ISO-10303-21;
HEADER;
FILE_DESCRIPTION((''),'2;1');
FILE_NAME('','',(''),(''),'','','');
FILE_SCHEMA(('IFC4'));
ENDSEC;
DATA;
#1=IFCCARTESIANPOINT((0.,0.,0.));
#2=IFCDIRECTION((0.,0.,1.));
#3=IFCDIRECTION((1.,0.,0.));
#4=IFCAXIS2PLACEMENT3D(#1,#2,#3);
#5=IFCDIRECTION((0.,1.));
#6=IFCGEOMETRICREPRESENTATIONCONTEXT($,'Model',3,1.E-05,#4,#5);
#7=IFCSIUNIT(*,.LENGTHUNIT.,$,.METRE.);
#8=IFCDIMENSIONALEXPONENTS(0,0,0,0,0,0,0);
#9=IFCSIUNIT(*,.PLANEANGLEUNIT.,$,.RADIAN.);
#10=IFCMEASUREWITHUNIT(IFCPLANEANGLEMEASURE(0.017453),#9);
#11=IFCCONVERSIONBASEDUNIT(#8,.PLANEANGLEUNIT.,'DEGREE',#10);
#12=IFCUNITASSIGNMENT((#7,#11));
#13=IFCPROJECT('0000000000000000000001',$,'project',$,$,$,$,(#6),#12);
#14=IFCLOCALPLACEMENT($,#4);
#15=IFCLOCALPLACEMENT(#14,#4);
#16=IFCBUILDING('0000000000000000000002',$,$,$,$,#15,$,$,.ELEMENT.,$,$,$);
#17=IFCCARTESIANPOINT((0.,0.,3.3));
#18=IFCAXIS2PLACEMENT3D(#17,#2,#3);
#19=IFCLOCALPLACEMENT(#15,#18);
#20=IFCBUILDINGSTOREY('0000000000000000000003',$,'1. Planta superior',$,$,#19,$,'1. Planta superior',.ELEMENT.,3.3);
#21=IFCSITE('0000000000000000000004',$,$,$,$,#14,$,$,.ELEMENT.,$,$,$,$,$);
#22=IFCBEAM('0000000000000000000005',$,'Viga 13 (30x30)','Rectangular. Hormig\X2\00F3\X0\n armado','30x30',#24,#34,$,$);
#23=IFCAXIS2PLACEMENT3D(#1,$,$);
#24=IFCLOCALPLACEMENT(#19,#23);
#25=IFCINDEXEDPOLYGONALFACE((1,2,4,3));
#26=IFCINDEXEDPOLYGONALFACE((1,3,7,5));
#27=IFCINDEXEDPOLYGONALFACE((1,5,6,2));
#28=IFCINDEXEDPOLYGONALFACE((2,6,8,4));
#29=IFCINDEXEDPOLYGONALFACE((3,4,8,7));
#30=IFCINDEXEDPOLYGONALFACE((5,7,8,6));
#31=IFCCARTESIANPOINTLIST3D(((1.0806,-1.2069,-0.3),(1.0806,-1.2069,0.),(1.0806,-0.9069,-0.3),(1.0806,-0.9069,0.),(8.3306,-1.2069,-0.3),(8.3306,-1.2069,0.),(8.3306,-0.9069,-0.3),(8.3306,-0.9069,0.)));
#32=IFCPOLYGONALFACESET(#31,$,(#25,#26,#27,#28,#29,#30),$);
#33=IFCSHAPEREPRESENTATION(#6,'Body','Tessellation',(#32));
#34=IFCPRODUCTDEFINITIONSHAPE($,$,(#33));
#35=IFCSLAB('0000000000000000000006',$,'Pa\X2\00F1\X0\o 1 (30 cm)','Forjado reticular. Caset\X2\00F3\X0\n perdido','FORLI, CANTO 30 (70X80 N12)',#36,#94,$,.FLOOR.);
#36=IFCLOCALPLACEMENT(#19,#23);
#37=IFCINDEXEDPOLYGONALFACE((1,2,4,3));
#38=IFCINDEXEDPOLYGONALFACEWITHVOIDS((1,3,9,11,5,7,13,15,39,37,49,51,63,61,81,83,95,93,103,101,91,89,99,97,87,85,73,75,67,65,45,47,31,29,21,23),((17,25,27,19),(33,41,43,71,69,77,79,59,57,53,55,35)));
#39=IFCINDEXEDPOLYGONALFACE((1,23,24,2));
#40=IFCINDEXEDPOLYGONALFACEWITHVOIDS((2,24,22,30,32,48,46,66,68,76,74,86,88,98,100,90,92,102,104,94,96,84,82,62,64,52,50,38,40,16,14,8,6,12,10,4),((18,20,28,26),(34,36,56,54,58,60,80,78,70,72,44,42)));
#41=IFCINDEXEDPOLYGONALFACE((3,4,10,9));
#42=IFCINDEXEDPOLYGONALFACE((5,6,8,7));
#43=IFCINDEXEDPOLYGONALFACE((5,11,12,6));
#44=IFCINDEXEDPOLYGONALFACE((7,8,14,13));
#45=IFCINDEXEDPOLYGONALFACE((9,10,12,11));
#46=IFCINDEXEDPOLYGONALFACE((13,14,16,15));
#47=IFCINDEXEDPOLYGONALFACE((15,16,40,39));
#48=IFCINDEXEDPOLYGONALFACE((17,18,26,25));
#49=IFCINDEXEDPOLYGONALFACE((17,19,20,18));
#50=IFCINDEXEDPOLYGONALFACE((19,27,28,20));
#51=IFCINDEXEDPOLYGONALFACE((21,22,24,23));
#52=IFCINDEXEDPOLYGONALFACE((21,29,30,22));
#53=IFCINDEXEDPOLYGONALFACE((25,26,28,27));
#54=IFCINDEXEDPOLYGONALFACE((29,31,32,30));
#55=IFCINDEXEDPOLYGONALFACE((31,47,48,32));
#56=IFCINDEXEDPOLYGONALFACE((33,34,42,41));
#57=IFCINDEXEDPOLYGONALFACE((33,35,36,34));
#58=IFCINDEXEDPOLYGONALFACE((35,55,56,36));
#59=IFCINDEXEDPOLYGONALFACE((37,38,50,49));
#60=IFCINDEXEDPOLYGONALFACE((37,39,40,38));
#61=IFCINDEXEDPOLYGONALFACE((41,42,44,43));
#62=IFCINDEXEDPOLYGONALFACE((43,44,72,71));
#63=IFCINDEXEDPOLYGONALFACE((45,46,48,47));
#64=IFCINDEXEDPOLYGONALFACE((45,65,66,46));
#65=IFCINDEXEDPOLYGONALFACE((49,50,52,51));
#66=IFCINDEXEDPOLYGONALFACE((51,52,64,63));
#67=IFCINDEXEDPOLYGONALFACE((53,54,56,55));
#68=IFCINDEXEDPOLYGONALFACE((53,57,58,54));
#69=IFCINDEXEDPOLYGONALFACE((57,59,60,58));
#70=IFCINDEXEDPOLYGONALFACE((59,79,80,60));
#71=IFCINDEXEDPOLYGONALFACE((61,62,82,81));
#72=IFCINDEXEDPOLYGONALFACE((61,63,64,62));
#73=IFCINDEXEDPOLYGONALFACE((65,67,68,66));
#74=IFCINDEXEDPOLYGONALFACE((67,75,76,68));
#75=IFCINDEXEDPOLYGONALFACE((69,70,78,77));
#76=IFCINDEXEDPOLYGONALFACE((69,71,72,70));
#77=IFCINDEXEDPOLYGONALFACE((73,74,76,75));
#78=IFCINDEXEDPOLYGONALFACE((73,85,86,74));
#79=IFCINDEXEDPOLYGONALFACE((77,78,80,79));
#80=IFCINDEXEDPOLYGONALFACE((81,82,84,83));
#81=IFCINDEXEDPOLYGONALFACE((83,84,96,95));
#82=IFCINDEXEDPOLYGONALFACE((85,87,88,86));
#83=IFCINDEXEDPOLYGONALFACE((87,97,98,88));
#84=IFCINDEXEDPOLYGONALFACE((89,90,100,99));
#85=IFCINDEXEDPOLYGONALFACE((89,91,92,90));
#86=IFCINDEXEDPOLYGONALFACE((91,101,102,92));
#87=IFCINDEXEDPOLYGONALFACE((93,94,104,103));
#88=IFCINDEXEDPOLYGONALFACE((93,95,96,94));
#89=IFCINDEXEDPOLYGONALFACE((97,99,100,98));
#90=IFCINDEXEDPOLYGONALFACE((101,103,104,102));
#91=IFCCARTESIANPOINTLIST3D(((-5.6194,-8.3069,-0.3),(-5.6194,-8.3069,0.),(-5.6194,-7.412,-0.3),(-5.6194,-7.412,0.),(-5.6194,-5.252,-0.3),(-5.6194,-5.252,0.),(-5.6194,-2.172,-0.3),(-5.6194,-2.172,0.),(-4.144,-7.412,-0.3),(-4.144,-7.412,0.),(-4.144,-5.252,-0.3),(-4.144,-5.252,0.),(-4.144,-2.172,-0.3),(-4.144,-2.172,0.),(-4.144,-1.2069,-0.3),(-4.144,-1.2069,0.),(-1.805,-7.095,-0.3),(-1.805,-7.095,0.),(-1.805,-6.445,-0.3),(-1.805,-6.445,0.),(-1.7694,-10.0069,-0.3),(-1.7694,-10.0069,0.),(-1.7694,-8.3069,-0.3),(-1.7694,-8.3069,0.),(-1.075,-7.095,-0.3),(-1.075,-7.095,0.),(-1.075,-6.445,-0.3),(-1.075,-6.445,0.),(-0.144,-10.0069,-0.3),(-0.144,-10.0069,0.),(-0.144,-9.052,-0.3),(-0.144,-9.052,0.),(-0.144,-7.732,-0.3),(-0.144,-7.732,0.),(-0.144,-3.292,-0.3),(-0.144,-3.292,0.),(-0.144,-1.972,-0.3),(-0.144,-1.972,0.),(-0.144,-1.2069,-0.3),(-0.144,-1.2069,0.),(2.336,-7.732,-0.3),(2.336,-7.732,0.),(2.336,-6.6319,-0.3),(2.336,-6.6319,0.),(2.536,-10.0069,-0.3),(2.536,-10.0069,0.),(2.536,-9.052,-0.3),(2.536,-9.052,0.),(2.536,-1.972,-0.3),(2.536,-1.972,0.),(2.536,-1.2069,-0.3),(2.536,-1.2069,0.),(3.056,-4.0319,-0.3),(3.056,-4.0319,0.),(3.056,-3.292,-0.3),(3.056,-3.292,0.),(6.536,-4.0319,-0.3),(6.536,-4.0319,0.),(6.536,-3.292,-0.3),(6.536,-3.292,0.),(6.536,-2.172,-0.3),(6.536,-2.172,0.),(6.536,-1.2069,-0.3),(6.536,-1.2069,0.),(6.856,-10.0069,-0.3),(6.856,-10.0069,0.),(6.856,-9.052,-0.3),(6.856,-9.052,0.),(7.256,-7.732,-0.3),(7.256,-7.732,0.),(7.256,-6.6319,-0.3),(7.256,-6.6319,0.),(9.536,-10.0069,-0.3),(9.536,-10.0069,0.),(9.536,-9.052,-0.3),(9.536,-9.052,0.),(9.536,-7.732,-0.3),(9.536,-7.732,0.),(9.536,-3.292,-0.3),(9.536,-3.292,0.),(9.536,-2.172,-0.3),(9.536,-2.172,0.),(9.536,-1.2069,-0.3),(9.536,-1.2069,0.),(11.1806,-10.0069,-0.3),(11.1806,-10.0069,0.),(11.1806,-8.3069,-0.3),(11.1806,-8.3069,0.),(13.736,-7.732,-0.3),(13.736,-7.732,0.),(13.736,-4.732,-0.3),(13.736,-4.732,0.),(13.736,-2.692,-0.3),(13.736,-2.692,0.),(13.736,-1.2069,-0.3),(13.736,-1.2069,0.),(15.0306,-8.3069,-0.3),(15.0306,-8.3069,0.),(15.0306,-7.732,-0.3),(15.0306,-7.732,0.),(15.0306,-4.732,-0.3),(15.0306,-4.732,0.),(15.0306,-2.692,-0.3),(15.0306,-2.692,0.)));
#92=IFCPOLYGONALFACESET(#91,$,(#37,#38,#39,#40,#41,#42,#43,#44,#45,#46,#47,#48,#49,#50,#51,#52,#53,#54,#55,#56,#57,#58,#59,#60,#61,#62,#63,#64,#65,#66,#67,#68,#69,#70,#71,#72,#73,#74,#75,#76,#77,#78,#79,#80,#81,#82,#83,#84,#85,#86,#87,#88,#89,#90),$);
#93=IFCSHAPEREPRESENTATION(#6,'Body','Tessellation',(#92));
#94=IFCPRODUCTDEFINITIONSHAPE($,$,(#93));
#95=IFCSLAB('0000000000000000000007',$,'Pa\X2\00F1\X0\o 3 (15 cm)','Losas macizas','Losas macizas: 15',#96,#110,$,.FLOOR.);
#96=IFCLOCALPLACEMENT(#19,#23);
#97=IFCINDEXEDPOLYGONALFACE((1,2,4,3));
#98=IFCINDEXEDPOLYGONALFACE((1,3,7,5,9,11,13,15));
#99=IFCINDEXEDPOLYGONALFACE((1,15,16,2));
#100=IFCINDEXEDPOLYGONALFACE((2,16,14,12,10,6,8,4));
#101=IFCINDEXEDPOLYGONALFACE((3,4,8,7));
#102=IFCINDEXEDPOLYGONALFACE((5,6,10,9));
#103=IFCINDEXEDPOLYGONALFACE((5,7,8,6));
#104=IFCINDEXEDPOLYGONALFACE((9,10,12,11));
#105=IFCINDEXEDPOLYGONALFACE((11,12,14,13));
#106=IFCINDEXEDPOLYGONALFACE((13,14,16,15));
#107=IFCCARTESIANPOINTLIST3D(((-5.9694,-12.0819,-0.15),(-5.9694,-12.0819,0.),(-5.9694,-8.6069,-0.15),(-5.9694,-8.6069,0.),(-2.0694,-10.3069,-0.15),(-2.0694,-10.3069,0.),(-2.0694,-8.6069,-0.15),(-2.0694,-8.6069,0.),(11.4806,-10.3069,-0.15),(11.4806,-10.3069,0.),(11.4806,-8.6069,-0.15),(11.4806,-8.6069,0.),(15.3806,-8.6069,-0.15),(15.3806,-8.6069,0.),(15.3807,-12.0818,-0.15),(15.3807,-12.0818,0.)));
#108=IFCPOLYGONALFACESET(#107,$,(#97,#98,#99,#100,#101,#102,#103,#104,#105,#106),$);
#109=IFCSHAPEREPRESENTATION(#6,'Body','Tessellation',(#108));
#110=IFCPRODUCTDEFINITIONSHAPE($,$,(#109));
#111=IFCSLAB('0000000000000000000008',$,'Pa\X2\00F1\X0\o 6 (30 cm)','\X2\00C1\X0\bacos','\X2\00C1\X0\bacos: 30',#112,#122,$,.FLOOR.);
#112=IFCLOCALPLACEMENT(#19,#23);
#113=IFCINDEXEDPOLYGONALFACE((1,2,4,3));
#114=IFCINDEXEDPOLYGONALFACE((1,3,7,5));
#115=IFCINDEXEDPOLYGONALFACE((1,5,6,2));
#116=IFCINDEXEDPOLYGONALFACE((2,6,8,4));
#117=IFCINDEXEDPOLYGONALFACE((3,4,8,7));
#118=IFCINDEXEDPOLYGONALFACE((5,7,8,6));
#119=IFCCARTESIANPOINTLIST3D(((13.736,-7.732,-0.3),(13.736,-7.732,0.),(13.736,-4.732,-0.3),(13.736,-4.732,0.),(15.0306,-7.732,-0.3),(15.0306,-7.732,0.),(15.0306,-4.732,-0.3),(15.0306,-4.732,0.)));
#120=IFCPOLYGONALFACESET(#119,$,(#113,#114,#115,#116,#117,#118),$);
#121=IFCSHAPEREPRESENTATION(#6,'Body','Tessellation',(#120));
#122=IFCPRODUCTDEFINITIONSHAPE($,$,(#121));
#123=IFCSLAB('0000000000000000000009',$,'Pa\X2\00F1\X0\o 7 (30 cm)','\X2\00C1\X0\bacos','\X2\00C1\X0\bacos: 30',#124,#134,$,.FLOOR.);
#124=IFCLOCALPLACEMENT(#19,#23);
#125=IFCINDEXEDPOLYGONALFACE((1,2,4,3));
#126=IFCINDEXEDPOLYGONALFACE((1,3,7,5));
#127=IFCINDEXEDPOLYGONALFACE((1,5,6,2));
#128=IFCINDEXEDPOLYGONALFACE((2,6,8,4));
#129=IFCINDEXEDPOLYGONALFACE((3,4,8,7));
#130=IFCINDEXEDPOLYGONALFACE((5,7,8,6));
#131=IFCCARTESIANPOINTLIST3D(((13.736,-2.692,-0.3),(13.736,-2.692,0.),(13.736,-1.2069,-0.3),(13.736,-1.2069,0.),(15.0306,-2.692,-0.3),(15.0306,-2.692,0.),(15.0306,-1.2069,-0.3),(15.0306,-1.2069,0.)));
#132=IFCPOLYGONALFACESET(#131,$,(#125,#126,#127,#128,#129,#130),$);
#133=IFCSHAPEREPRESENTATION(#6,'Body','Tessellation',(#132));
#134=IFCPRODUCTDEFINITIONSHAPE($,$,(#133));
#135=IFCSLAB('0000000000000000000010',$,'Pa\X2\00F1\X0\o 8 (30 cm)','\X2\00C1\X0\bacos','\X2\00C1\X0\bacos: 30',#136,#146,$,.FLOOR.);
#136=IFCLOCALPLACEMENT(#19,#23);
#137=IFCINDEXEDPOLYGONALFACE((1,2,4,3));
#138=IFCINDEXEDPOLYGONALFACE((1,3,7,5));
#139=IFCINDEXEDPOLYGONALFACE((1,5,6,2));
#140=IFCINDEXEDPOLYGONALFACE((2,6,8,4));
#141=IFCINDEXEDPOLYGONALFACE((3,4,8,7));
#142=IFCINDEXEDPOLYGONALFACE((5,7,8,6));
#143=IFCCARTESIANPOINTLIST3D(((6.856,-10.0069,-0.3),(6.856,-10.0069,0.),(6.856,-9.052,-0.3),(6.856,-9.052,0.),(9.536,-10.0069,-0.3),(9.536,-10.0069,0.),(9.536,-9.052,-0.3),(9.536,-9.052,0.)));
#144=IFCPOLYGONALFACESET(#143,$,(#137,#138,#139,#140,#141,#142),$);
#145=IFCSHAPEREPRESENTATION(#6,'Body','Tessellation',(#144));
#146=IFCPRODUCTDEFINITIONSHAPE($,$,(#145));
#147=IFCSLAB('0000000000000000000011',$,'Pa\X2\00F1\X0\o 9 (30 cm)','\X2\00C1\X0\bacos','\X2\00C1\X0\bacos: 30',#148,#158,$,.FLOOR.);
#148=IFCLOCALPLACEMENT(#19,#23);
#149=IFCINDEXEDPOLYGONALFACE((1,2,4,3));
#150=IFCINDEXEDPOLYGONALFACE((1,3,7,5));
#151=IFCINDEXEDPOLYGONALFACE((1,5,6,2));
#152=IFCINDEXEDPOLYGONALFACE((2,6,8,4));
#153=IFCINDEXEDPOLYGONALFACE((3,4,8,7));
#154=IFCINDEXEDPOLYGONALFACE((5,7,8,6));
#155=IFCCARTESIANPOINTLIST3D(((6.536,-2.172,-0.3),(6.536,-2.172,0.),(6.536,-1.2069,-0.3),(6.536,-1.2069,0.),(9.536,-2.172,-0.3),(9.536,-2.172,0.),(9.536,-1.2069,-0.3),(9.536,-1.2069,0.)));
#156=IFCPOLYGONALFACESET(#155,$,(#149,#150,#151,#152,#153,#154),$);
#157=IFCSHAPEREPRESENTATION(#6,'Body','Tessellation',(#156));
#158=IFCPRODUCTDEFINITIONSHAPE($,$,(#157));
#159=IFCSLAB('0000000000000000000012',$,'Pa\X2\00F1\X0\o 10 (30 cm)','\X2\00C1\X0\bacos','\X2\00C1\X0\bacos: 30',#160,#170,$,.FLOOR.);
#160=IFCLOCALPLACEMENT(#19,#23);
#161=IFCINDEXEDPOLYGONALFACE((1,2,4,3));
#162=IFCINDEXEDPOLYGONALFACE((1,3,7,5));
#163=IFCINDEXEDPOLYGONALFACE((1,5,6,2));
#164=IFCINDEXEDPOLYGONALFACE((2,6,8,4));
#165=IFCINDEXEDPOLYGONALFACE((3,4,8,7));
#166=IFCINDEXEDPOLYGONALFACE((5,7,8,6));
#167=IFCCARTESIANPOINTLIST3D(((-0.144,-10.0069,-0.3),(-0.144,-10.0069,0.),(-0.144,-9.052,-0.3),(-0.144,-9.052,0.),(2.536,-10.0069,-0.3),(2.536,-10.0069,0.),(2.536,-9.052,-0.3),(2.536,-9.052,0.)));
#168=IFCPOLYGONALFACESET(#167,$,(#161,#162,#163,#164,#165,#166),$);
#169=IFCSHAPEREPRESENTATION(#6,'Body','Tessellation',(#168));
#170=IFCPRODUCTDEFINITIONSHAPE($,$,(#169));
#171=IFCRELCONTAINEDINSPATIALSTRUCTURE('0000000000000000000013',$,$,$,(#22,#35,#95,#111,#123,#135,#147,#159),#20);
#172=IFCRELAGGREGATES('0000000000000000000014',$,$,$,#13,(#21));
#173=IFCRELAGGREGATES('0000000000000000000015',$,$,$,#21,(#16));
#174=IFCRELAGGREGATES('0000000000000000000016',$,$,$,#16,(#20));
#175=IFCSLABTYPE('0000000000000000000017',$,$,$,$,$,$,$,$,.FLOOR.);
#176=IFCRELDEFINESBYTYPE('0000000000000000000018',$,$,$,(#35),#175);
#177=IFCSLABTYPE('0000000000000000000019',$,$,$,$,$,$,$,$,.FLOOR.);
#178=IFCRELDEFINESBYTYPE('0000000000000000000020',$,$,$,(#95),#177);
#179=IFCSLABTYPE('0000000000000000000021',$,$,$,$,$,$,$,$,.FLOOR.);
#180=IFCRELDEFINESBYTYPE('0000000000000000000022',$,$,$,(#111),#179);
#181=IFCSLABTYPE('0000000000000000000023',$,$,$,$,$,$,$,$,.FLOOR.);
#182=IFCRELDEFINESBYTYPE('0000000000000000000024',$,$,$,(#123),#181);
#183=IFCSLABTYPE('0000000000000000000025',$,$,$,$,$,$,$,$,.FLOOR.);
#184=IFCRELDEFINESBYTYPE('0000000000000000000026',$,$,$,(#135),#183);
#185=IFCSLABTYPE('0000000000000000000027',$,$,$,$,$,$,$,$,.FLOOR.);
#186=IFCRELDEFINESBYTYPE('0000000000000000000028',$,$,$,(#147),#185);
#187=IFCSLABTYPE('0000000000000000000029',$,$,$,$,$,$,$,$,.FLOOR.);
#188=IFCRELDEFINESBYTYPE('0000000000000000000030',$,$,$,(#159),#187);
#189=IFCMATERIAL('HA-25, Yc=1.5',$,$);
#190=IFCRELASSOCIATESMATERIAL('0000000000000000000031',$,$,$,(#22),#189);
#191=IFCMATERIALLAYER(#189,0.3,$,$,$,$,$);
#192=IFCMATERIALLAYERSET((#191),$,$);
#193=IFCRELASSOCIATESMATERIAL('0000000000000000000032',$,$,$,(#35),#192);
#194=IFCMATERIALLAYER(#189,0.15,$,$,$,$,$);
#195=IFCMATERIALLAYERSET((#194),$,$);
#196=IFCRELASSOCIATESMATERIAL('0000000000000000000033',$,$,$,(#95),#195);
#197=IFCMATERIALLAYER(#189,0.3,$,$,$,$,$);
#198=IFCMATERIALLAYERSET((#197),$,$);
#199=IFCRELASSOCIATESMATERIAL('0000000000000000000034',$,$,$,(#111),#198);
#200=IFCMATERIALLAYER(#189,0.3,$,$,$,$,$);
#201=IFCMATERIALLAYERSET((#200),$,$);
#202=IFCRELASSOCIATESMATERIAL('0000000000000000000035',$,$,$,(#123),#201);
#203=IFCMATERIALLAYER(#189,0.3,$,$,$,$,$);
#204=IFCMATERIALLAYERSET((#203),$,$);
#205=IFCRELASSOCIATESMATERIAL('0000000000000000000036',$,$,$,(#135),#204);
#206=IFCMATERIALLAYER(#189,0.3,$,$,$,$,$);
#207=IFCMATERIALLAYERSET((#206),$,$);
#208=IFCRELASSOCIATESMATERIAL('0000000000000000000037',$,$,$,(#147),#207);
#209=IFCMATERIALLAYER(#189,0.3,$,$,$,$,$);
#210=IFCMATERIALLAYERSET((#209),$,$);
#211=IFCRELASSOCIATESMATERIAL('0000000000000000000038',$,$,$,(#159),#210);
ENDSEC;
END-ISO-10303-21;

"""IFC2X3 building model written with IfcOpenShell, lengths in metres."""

from ifc_helpers import new_model, entity, si_unit, converted_unit, direction, frame, frame_2d, origin_with_axes, place, context, project, spatial, polyline, rectangle, outline, extrude, material, layer, layer_set, layer_usage, type_object, element, save


model = new_model("IFC2X3")

# Units and contexts
model_context = context("Model", 3, precision=1e-05, world=origin_with_axes(), true_north=direction((0.0, 1.0)))
ifc_project = project(units=[si_unit("LENGTHUNIT", "METRE"), converted_unit("PLANEANGLEUNIT", "DEGREE", entity("IfcPlaneAngleMeasure", 0.017453), si_unit("PLANEANGLEUNIT", "RADIAN"), dimensions=[0, 0, 0, 0, 0, 0, 0])], contexts=[model_context])

# Site, building, storey
site_placement = place(None, origin_with_axes())
site = spatial("IfcSite", under=ifc_project, at=site_placement, CompositionType="ELEMENT")
building_placement = place(site_placement, origin_with_axes())
building = spatial("IfcBuilding", under=site, at=building_placement, CompositionType="ELEMENT")
storey_placement = place(building_placement, frame((0.0, 0.0, 3.3), z_axis=(0.0, 0.0, 1.0), x_axis=(1.0, 0.0, 0.0)))
storey = spatial("IfcBuildingStorey", under=building, at=storey_placement, Name="1. Planta superior", LongName="1. Planta superior", CompositionType="ELEMENT", Elevation=3.3)

# Beam
ifc_material_1 = material(Name="HA-25, Yc=1.5")
beam_placement = place(storey_placement, frame((1.0806, -1.0569, 0.0), z_axis=(1.0, 0.0, 0.0), x_axis=(0.0, 1.0, 0.0)))
element("IfcBeam", 1, at=beam_placement, inside=storey, material=ifc_material_1, Name="Viga 13 (30x30)", Description="Rectangular. Hormigón armado", ObjectType="30x30", context=model_context, shape_type="SweptSolid", body=[
    extrude(rectangle(XDim=0.3, YDim=0.3, at=frame_2d((0.0, -0.15), x_axis=(1.0, 0.0))), origin_with_axes(), (0.0, 0.0, 1.0), 7.25),
])

# Slab, openings
ifc_layer_1 = layer(ifc_material_1, 0.3)
ifc_layer_set_1 = layer_set([ifc_layer_1])
ifc_layer_usage_1 = layer_usage(ifc_layer_set_1, "AXIS3", "POSITIVE", 0.0)
slab_type_1 = type_object("IfcSlabType", PredefinedType="FLOOR")
slab_1_placement = place(storey_placement, frame((0.0, 0.0, -0.3), z_axis=(0.0, 0.0, 1.0), x_axis=(1.0, 0.0, 0.0)))
slab_1 = element("IfcSlab", 2, at=slab_1_placement, inside=storey, type_object=slab_type_1, material=ifc_layer_usage_1, Name="Paño 1 (30 cm)", Description="Forjado reticular. Casetón perdido", ObjectType="FORLI, CANTO 30 (70X80 N12)", PredefinedType="FLOOR", context=model_context, shape_type="SweptSolid", body=[
    extrude(outline(polyline([(15.0306, -8.3069), (15.0306, -7.732), (13.736, -7.732), (13.736, -4.732), (15.0306, -4.732), (15.0306, -2.692), (13.736, -2.692), (13.736, -1.2069), (9.536, -1.2069), (9.536, -2.172), (6.536, -2.172), (6.536, -1.2069), (2.536, -1.2069), (2.536, -1.972), (-0.144, -1.972), (-0.144, -1.2069), (-4.144, -1.2069), (-4.144, -2.172), (-5.6194, -2.172), (-5.6194, -5.252), (-4.144, -5.252), (-4.144, -7.412), (-5.6194, -7.412), (-5.6194, -8.3069), (-1.7694, -8.3069), (-1.7694, -10.0069), (-0.144, -10.0069), (-0.144, -9.052), (2.536, -9.052), (2.536, -10.0069), (6.856, -10.0069), (6.856, -9.052), (9.536, -9.052), (9.536, -10.0069), (11.1806, -10.0069), (11.1806, -8.3069), (15.0306, -8.3069)])), origin_with_axes(), (0.0, 0.0, 1.0), 0.3),
])
opening_1_placement = place(slab_1_placement, frame((-0.144, -7.732, 0.0), z_axis=(0.0, 0.0, 1.0), x_axis=(1.0, 0.0, 0.0)))
element("IfcOpeningElement", 3, at=opening_1_placement, cuts=slab_1, ObjectType="Opening", context=model_context, shape_type="SweptSolid", body=[
    extrude(outline(polyline([(7.4, 0.0), (9.68, 0.0), (9.68, 4.44), (6.68, 4.44), (6.68, 3.7001), (3.2, 3.7001), (3.2, 4.44), (0.0, 4.44), (0.0, 0.0), (2.48, 0.0), (2.48, 1.1001), (7.4, 1.1001), (7.4, 0.0)])), origin_with_axes(), (0.0, 0.0, 1.0), 0.3),
])
opening_2_placement = place(slab_1_placement, frame((-1.805, -7.095, 0.0), z_axis=(0.0, 0.0, 1.0), x_axis=(1.0, 0.0, 0.0)))
element("IfcOpeningElement", 4, at=opening_2_placement, cuts=slab_1, ObjectType="Opening", context=model_context, shape_type="SweptSolid", body=[
    extrude(outline(polyline([(0.0, 0.0), (0.73, 0.0), (0.73, 0.65), (0.0, 0.65), (0.0, 0.0)])), origin_with_axes(), (0.0, 0.0, 1.0), 0.3),
])

# Slabs
ifc_layer_2 = layer(ifc_material_1, 0.15)
ifc_layer_set_2 = layer_set([ifc_layer_2])
ifc_layer_usage_2 = layer_usage(ifc_layer_set_2, "AXIS3", "POSITIVE", 0.0)
slab_type_2 = type_object("IfcSlabType", PredefinedType="FLOOR")
slab_2_placement = place(storey_placement, frame((0.0, 0.0, -0.15), z_axis=(0.0, 0.0, 1.0), x_axis=(1.0, 0.0, 0.0)))
element("IfcSlab", 5, at=slab_2_placement, inside=storey, type_object=slab_type_2, material=ifc_layer_usage_2, Name="Paño 3 (15 cm)", Description="Losas macizas", ObjectType="Losas macizas: 15", PredefinedType="FLOOR", context=model_context, shape_type="SweptSolid", body=[
    extrude(outline(polyline([(15.3806, -8.6069), (11.4806, -8.6069), (11.4806, -10.3069), (-2.0694, -10.3069), (-2.0694, -8.6069), (-5.9694, -8.6069), (-5.9694, -12.0819), (15.3807, -12.0818), (15.3806, -8.6069)])), origin_with_axes(), (0.0, 0.0, 1.0), 0.15),
])
ifc_layer_3 = layer(ifc_material_1, 0.3)
ifc_layer_set_3 = layer_set([ifc_layer_3])
ifc_layer_usage_3 = layer_usage(ifc_layer_set_3, "AXIS3", "POSITIVE", 0.0)
slab_type_3 = type_object("IfcSlabType", PredefinedType="FLOOR")
slab_3_placement = place(storey_placement, frame((0.0, 0.0, -0.3), z_axis=(0.0, 0.0, 1.0), x_axis=(1.0, 0.0, 0.0)))
element("IfcSlab", 6, at=slab_3_placement, inside=storey, type_object=slab_type_3, material=ifc_layer_usage_3, Name="Paño 6 (30 cm)", Description="Ábacos", ObjectType="Ábacos: 30", PredefinedType="FLOOR", context=model_context, shape_type="SweptSolid", body=[
    extrude(outline(polyline([(15.0306, -4.732), (13.736, -4.732), (13.736, -7.732), (15.0306, -7.732), (15.0306, -4.732)])), origin_with_axes(), (0.0, 0.0, 1.0), 0.3),
])
ifc_layer_4 = layer(ifc_material_1, 0.3)
ifc_layer_set_4 = layer_set([ifc_layer_4])
ifc_layer_usage_4 = layer_usage(ifc_layer_set_4, "AXIS3", "POSITIVE", 0.0)
slab_type_4 = type_object("IfcSlabType", PredefinedType="FLOOR")
slab_4_placement = place(storey_placement, frame((0.0, 0.0, -0.3), z_axis=(0.0, 0.0, 1.0), x_axis=(1.0, 0.0, 0.0)))
element("IfcSlab", 7, at=slab_4_placement, inside=storey, type_object=slab_type_4, material=ifc_layer_usage_4, Name="Paño 7 (30 cm)", Description="Ábacos", ObjectType="Ábacos: 30", PredefinedType="FLOOR", context=model_context, shape_type="SweptSolid", body=[
    extrude(outline(polyline([(15.0306, -1.2069), (13.736, -1.2069), (13.736, -2.692), (15.0306, -2.692), (15.0306, -1.2069)])), origin_with_axes(), (0.0, 0.0, 1.0), 0.3),
])
ifc_layer_5 = layer(ifc_material_1, 0.3)
ifc_layer_set_5 = layer_set([ifc_layer_5])
ifc_layer_usage_5 = layer_usage(ifc_layer_set_5, "AXIS3", "POSITIVE", 0.0)
slab_type_5 = type_object("IfcSlabType", PredefinedType="FLOOR")
slab_5_placement = place(storey_placement, frame((0.0, 0.0, -0.3), z_axis=(0.0, 0.0, 1.0), x_axis=(1.0, 0.0, 0.0)))
element("IfcSlab", 8, at=slab_5_placement, inside=storey, type_object=slab_type_5, material=ifc_layer_usage_5, Name="Paño 8 (30 cm)", Description="Ábacos", ObjectType="Ábacos: 30", PredefinedType="FLOOR", context=model_context, shape_type="SweptSolid", body=[
    extrude(outline(polyline([(9.536, -10.0069), (9.536, -9.052), (6.856, -9.052), (6.856, -10.0069), (9.536, -10.0069)])), origin_with_axes(), (0.0, 0.0, 1.0), 0.3),
])
ifc_layer_6 = layer(ifc_material_1, 0.3)
ifc_layer_set_6 = layer_set([ifc_layer_6])
ifc_layer_usage_6 = layer_usage(ifc_layer_set_6, "AXIS3", "POSITIVE", 0.0)
slab_type_6 = type_object("IfcSlabType", PredefinedType="FLOOR")
slab_6_placement = place(storey_placement, frame((0.0, 0.0, -0.3), z_axis=(0.0, 0.0, 1.0), x_axis=(1.0, 0.0, 0.0)))
element("IfcSlab", 9, at=slab_6_placement, inside=storey, type_object=slab_type_6, material=ifc_layer_usage_6, Name="Paño 9 (30 cm)", Description="Ábacos", ObjectType="Ábacos: 30", PredefinedType="FLOOR", context=model_context, shape_type="SweptSolid", body=[
    extrude(outline(polyline([(9.536, -1.2069), (6.536, -1.2069), (6.536, -2.172), (9.536, -2.172), (9.536, -1.2069)])), origin_with_axes(), (0.0, 0.0, 1.0), 0.3),
])
ifc_layer_7 = layer(ifc_material_1, 0.3)
ifc_layer_set_7 = layer_set([ifc_layer_7])
ifc_layer_usage_7 = layer_usage(ifc_layer_set_7, "AXIS3", "POSITIVE", 0.0)
slab_type_7 = type_object("IfcSlabType", PredefinedType="FLOOR")
slab_7_placement = place(storey_placement, frame((0.0, 0.0, -0.3), z_axis=(0.0, 0.0, 1.0), x_axis=(1.0, 0.0, 0.0)))
element("IfcSlab", 10, at=slab_7_placement, inside=storey, type_object=slab_type_7, material=ifc_layer_usage_7, Name="Paño 10 (30 cm)", Description="Ábacos", ObjectType="Ábacos: 30", PredefinedType="FLOOR", context=model_context, shape_type="SweptSolid", body=[
    extrude(outline(polyline([(2.536, -10.0069), (2.536, -9.052), (-0.144, -9.052), (-0.144, -10.0069), (2.536, -10.0069)])), origin_with_axes(), (0.0, 0.0, 1.0), 0.3),
])

save(model, "model.ifc")
